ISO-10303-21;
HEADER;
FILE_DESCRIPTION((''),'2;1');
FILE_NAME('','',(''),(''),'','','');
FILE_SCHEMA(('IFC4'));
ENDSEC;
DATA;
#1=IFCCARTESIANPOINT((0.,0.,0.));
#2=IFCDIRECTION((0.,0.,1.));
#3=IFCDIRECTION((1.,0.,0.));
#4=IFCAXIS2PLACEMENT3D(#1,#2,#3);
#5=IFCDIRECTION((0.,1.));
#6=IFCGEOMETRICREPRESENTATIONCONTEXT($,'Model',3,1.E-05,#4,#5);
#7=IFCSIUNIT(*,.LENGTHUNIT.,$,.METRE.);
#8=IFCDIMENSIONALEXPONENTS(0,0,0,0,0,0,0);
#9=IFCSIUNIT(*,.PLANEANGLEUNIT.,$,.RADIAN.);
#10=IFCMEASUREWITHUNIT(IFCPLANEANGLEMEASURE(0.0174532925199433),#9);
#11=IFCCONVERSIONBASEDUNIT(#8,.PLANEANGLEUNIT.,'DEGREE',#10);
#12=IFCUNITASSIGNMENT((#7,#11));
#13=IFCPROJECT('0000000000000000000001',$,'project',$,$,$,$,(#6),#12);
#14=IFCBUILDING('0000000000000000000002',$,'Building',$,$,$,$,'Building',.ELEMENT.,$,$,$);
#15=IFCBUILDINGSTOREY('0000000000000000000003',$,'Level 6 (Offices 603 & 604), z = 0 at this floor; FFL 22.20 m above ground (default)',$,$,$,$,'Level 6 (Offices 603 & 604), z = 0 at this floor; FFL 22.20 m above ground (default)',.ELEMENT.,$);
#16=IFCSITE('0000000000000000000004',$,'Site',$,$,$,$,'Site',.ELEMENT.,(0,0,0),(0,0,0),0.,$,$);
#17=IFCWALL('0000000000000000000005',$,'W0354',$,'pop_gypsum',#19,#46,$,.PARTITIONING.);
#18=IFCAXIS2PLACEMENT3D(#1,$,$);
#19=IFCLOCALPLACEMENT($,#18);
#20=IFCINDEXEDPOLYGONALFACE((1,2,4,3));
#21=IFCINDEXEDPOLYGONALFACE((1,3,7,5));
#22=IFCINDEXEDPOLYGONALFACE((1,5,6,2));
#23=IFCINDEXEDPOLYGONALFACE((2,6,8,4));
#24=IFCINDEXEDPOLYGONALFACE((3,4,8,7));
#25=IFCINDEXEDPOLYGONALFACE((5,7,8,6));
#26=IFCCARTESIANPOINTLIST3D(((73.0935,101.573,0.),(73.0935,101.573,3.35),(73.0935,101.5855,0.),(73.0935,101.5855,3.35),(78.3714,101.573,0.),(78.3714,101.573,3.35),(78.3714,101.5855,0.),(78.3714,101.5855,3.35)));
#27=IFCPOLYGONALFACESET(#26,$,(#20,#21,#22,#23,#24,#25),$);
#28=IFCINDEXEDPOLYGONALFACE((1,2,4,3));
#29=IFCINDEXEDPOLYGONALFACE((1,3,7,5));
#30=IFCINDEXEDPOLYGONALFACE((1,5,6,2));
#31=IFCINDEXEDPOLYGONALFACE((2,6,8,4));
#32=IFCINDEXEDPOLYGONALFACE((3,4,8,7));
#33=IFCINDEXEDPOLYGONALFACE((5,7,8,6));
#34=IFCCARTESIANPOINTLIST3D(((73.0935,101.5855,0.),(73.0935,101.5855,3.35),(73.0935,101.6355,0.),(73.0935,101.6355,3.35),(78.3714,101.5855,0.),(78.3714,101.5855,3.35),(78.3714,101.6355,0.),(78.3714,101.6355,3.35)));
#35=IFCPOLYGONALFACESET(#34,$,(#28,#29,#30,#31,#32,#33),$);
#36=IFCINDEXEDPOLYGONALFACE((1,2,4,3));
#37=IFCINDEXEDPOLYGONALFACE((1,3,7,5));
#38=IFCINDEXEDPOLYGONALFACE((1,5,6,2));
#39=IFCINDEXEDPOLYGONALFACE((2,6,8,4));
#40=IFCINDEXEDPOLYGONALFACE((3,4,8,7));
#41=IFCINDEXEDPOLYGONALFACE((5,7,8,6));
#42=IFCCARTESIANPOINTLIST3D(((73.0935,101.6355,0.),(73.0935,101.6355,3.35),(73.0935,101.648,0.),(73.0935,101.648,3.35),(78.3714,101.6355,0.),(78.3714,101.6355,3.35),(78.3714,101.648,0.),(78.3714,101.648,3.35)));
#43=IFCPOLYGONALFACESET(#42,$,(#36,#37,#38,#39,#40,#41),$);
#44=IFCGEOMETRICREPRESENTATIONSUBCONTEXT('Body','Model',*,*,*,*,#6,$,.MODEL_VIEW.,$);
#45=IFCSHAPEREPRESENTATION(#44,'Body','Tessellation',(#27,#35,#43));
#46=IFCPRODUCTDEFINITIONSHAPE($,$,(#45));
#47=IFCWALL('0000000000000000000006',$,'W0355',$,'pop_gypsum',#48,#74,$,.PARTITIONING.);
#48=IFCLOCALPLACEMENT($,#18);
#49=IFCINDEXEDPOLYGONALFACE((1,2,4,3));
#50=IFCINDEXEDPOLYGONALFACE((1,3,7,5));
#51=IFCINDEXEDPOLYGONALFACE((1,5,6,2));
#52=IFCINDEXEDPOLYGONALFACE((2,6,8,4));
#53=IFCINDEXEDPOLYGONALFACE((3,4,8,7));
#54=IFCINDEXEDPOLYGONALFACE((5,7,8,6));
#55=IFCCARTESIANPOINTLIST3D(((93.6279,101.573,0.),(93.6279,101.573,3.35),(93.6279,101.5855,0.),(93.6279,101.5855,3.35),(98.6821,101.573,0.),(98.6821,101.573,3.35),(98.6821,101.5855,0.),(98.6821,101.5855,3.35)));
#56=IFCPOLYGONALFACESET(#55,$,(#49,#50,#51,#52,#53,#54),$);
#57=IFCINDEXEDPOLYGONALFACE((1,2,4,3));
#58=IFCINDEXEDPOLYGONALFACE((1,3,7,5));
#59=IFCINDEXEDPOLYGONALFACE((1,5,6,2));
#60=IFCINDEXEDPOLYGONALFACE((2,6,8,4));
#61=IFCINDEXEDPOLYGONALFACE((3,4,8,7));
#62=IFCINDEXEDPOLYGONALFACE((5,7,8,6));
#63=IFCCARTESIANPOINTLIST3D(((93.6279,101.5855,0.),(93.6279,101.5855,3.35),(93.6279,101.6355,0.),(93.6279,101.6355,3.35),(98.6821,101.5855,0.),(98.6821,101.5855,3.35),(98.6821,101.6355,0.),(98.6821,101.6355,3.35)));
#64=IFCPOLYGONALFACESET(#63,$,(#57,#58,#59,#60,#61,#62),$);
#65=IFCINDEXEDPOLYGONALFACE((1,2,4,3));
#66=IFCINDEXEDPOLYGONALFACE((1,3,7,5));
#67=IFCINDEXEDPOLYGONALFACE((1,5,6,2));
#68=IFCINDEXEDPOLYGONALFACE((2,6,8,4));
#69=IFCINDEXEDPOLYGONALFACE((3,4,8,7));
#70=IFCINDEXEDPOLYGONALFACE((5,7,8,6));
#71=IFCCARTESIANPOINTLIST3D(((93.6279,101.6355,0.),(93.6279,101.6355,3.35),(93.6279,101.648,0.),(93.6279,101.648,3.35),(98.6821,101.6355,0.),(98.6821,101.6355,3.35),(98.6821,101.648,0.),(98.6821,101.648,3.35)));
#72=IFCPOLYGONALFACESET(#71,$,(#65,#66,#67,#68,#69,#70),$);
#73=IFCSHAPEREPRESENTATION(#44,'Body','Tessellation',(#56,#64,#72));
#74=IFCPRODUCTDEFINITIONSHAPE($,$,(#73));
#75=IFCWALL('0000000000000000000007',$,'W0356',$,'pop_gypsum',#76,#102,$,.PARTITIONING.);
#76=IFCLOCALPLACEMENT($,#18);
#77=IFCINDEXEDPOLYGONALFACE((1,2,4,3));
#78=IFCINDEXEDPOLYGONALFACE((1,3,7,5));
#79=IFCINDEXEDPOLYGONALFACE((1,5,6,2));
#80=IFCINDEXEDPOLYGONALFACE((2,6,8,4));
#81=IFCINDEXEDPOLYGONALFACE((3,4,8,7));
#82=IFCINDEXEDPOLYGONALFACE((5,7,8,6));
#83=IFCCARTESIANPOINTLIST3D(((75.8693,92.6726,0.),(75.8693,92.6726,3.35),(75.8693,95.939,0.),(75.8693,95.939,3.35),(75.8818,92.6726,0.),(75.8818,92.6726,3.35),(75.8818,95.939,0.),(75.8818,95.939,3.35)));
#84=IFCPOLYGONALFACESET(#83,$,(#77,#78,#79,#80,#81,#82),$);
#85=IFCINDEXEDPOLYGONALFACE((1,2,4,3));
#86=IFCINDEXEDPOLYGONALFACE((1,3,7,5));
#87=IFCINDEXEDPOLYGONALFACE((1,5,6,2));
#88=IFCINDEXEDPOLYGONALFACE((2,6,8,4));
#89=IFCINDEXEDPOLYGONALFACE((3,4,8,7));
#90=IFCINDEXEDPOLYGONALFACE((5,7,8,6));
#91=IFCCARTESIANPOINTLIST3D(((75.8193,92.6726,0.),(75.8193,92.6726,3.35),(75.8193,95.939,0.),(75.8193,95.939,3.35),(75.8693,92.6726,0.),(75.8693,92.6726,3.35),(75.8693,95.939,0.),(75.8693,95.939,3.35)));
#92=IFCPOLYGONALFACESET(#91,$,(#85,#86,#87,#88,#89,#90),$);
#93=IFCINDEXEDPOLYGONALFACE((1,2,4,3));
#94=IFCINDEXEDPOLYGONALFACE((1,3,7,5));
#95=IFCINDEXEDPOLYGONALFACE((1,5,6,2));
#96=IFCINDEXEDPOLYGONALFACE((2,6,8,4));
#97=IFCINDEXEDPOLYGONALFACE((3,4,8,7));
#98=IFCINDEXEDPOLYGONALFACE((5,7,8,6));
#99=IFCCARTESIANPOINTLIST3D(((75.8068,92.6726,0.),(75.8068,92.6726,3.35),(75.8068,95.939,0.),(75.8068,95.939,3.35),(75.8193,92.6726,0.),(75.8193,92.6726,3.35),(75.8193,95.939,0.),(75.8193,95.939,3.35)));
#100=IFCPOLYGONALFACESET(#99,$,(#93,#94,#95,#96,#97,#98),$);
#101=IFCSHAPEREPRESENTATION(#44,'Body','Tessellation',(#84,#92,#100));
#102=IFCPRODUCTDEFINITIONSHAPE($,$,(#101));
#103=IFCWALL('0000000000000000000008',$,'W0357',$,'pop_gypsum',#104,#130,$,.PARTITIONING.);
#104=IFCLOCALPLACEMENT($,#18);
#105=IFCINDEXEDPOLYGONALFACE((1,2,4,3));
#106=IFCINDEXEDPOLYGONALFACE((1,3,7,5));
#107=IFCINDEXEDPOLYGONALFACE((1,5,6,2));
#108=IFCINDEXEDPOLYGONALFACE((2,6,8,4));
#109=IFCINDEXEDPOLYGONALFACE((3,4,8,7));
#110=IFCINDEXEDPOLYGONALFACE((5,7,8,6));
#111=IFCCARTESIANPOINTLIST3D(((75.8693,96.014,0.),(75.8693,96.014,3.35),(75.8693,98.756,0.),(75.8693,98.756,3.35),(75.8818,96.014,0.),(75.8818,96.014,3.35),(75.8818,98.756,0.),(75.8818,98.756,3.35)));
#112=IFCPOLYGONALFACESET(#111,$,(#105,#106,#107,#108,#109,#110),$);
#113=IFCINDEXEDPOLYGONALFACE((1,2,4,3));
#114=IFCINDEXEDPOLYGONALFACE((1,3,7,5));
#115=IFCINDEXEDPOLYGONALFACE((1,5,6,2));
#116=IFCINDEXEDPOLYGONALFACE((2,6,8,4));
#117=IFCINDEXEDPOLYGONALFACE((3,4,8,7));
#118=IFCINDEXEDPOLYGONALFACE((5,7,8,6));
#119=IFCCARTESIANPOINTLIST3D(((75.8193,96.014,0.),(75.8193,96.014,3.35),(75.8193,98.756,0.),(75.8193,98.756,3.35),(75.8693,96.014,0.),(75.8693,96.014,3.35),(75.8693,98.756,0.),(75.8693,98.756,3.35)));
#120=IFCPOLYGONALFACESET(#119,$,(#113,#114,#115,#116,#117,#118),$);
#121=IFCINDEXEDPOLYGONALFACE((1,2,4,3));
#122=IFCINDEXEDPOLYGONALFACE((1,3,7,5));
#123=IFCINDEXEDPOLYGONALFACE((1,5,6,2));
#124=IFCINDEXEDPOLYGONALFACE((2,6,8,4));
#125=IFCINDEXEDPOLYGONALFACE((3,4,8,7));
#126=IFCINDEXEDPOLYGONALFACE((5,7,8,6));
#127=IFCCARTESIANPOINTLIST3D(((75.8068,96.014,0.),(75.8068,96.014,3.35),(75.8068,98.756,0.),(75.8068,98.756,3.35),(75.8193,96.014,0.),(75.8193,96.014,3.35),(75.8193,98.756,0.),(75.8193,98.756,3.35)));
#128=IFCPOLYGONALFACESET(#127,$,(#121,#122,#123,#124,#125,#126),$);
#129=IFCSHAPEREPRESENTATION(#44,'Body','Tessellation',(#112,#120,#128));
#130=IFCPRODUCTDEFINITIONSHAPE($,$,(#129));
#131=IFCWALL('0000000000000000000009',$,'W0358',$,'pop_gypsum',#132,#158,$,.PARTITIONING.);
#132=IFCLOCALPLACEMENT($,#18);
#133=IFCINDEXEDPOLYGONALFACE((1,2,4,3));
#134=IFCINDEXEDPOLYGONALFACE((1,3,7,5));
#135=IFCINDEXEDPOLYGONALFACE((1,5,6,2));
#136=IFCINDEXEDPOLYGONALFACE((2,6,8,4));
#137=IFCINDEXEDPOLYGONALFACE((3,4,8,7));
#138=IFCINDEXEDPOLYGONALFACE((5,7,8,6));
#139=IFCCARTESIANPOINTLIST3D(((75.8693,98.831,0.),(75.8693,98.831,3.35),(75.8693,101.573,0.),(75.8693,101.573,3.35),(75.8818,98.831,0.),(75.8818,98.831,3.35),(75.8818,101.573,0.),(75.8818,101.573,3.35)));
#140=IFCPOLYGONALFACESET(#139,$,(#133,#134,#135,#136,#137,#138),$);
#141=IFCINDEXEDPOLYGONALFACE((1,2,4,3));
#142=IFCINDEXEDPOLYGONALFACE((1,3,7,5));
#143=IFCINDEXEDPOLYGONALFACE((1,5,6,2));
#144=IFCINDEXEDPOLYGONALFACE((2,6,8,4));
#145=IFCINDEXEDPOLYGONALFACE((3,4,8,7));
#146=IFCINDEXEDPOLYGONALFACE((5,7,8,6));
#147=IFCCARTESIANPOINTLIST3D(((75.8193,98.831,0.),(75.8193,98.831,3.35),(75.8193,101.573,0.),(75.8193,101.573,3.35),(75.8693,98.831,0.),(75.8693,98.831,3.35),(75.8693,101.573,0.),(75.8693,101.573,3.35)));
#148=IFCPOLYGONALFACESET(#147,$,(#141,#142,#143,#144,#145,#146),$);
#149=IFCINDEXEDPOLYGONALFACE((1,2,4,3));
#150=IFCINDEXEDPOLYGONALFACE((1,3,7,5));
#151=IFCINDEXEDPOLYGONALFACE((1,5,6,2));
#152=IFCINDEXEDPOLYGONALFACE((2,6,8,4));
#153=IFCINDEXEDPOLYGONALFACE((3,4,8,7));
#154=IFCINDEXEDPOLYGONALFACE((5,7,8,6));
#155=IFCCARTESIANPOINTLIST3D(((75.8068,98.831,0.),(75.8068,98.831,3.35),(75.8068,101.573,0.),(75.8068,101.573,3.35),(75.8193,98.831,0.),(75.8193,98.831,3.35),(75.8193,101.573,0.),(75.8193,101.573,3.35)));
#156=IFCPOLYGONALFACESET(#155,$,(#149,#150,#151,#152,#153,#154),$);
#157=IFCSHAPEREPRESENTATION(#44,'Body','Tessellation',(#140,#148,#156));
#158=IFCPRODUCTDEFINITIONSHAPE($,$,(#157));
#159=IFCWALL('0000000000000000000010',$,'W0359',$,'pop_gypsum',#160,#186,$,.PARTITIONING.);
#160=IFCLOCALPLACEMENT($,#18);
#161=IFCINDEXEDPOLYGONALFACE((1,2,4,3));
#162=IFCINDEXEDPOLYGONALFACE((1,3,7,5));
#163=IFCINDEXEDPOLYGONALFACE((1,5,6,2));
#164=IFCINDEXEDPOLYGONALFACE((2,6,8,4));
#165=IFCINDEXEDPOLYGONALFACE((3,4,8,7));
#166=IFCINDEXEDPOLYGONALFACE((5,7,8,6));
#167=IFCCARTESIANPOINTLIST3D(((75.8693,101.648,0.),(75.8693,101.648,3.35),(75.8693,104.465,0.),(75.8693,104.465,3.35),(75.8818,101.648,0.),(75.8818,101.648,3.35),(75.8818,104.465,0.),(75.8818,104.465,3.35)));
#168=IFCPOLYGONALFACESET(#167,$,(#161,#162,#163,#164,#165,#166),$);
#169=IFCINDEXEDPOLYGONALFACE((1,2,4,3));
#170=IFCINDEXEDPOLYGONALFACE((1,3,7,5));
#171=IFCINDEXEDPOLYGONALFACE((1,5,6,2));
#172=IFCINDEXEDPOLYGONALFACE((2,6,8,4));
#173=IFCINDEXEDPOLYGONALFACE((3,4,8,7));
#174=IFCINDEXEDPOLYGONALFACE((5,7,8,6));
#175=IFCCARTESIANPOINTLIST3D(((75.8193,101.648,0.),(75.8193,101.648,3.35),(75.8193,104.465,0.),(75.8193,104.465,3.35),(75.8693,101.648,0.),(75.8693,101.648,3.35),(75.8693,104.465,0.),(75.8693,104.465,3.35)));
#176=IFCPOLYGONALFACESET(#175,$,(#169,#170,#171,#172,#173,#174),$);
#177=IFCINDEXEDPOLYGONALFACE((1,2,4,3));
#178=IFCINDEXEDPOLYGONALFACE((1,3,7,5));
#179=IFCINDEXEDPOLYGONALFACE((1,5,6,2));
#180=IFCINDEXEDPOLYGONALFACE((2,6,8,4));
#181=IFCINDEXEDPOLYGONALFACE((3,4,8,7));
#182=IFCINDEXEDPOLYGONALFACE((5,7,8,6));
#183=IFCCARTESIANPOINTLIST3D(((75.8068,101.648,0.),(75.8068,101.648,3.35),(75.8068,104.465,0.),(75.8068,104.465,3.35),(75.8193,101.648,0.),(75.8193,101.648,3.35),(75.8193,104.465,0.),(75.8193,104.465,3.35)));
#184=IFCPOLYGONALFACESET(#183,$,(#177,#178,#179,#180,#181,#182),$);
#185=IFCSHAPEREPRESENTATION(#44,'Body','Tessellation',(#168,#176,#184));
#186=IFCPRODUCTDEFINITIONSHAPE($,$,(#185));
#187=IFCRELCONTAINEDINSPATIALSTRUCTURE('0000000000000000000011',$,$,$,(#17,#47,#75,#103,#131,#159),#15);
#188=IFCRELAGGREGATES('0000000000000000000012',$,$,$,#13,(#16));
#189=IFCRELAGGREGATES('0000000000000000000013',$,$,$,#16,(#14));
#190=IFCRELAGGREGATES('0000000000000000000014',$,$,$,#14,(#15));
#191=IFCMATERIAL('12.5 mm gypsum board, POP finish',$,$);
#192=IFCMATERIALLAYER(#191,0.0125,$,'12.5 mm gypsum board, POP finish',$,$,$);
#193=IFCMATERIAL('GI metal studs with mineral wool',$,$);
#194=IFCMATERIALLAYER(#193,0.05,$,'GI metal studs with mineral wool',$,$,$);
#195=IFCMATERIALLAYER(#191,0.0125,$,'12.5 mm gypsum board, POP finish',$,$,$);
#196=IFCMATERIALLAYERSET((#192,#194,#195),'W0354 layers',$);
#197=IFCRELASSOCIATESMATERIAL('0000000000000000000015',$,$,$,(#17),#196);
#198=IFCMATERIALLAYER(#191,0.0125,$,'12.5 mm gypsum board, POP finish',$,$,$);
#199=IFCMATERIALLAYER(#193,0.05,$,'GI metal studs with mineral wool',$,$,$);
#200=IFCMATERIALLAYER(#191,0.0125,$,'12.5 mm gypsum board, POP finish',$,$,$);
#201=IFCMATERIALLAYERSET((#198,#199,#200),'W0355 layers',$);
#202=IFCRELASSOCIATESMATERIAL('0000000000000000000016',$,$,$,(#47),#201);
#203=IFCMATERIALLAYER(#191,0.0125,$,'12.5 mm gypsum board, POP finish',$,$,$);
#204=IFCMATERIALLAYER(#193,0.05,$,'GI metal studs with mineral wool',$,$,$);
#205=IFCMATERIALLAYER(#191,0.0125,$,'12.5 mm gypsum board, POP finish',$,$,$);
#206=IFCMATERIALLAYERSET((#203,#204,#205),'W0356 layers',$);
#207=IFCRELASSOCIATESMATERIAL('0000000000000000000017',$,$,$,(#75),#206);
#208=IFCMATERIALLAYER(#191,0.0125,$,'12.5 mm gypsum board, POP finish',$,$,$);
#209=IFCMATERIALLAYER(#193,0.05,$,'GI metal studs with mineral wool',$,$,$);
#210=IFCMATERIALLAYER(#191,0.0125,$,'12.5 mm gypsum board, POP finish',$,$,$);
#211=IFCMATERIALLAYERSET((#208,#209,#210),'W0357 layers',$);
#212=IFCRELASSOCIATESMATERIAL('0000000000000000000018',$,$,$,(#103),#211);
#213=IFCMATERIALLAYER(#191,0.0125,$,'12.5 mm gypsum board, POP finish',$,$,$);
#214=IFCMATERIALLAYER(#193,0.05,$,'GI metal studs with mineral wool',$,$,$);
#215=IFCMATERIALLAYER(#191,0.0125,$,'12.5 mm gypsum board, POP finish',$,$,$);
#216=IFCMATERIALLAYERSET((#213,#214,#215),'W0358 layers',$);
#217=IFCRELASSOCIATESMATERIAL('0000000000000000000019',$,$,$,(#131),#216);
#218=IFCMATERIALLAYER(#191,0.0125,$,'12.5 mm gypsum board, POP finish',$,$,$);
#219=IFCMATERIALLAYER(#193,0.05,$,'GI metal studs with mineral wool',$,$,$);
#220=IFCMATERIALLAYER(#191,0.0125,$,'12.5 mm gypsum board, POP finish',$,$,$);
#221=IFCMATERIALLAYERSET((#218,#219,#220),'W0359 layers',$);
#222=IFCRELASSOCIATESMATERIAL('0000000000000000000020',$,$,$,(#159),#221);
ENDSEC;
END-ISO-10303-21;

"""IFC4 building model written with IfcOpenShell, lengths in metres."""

from ifc_helpers import new_model, entity, si_unit, converted_unit, direction, frame, frame_2d, origin_with_axes, place, context, subcontext, project, spatial, rectangle, extrude, material, layer, layer_set, layer_usage, element, save


model = new_model("IFC4")

# Units and contexts
model_context = context("Model", 3, precision=1e-05, world=origin_with_axes(), true_north=direction((0.0, 1.0)))
body_context = subcontext(model_context, "Body", "Model", "MODEL_VIEW")
ifc_project = project(units=[si_unit("LENGTHUNIT", "METRE"), converted_unit("PLANEANGLEUNIT", "DEGREE", entity("IfcPlaneAngleMeasure", 0.0174532925199433), si_unit("PLANEANGLEUNIT", "RADIAN"), dimensions=[0, 0, 0, 0, 0, 0, 0])], contexts=[model_context])

# Site, building, storey
site = spatial("IfcSite", under=ifc_project, Name="Site", LongName="Site", CompositionType="ELEMENT", RefLatitude=(0, 0, 0), RefLongitude=(0, 0, 0), RefElevation=0.0)
building = spatial("IfcBuilding", under=site, Name="Building", LongName="Building", CompositionType="ELEMENT")
storey = spatial("IfcBuildingStorey", under=building, Name="Level 6 (Offices 603 & 604), z = 0 at this floor; FFL 22.20 m above ground (default)", LongName="Level 6 (Offices 603 & 604), z = 0 at this floor; FFL 22.20 m above ground (default)", CompositionType="ELEMENT")

# Shared definitions
placement = place(None, origin_with_axes())

# Walls
ifc_material_1 = material(Name="12.5 mm gypsum board, POP finish")
ifc_material_2 = material(Name="GI metal studs with mineral wool")
ifc_layer_1 = layer(ifc_material_1, 0.0125, Name="12.5 mm gypsum board, POP finish")
ifc_layer_2 = layer(ifc_material_2, 0.05, Name="GI metal studs with mineral wool")
ifc_layer_3 = layer(ifc_material_1, 0.0125, Name="12.5 mm gypsum board, POP finish")
ifc_layer_set_1 = layer_set([ifc_layer_1, ifc_layer_2, ifc_layer_3], Name="W0354 layers")
ifc_layer_usage_1 = layer_usage(ifc_layer_set_1, "AXIS2", "POSITIVE", -0.0375)
element("IfcWall", 1, at=placement, inside=storey, material=ifc_layer_usage_1, Name="W0354", ObjectType="pop_gypsum", PredefinedType="PARTITIONING", context=body_context, shape_type="SweptSolid", body=[
    extrude(rectangle(XDim=5.2779, YDim=0.0125, at=frame_2d((0.0, 0.0), x_axis=(1.0, 0.0))), frame((75.7325, 101.5793, 0.0), z_axis=(0.0, 0.0, 1.0), x_axis=(1.0, 0.0, 0.0)), (0.0, 0.0, 1.0), 3.35),
    extrude(rectangle(XDim=5.2779, YDim=0.05, at=frame_2d((0.0, 0.0312), x_axis=(1.0, 0.0))), frame((75.7325, 101.5793, 0.0), z_axis=(0.0, 0.0, 1.0), x_axis=(1.0, 0.0, 0.0)), (0.0, 0.0, 1.0), 3.35),
    extrude(rectangle(XDim=5.2779, YDim=0.0125, at=frame_2d((0.0, 0.0625), x_axis=(1.0, 0.0))), frame((75.7325, 101.5793, 0.0), z_axis=(0.0, 0.0, 1.0), x_axis=(1.0, 0.0, 0.0)), (0.0, 0.0, 1.0), 3.35),
])
ifc_layer_4 = layer(ifc_material_1, 0.0125, Name="12.5 mm gypsum board, POP finish")
ifc_layer_5 = layer(ifc_material_2, 0.05, Name="GI metal studs with mineral wool")
ifc_layer_6 = layer(ifc_material_1, 0.0125, Name="12.5 mm gypsum board, POP finish")
ifc_layer_set_2 = layer_set([ifc_layer_4, ifc_layer_5, ifc_layer_6], Name="W0355 layers")
ifc_layer_usage_2 = layer_usage(ifc_layer_set_2, "AXIS2", "POSITIVE", -0.0375)
element("IfcWall", 2, at=placement, inside=storey, material=ifc_layer_usage_2, Name="W0355", ObjectType="pop_gypsum", PredefinedType="PARTITIONING", context=body_context, shape_type="SweptSolid", body=[
    extrude(rectangle(XDim=5.0542, YDim=0.0125, at=frame_2d((0.0, 0.0), x_axis=(1.0, 0.0))), frame((96.155, 101.5793, 0.0), z_axis=(0.0, 0.0, 1.0), x_axis=(1.0, 0.0, 0.0)), (0.0, 0.0, 1.0), 3.35),
    extrude(rectangle(XDim=5.0542, YDim=0.05, at=frame_2d((0.0, 0.0312), x_axis=(1.0, 0.0))), frame((96.155, 101.5793, 0.0), z_axis=(0.0, 0.0, 1.0), x_axis=(1.0, 0.0, 0.0)), (0.0, 0.0, 1.0), 3.35),
    extrude(rectangle(XDim=5.0542, YDim=0.0125, at=frame_2d((0.0, 0.0625), x_axis=(1.0, 0.0))), frame((96.155, 101.5793, 0.0), z_axis=(0.0, 0.0, 1.0), x_axis=(1.0, 0.0, 0.0)), (0.0, 0.0, 1.0), 3.35),
])
ifc_layer_7 = layer(ifc_material_1, 0.0125, Name="12.5 mm gypsum board, POP finish")
ifc_layer_8 = layer(ifc_material_2, 0.05, Name="GI metal studs with mineral wool")
ifc_layer_9 = layer(ifc_material_1, 0.0125, Name="12.5 mm gypsum board, POP finish")
ifc_layer_set_3 = layer_set([ifc_layer_7, ifc_layer_8, ifc_layer_9], Name="W0356 layers")
ifc_layer_usage_3 = layer_usage(ifc_layer_set_3, "AXIS2", "POSITIVE", -0.0375)
element("IfcWall", 3, at=placement, inside=storey, material=ifc_layer_usage_3, Name="W0356", ObjectType="pop_gypsum", PredefinedType="PARTITIONING", context=body_context, shape_type="SweptSolid", body=[
    extrude(rectangle(XDim=3.2664, YDim=0.0125, at=frame_2d((0.0, 0.0), x_axis=(0.0, 1.0))), frame((75.8756, 94.3058, 0.0), z_axis=(0.0, 0.0, 1.0), x_axis=(1.0, 0.0, 0.0)), (0.0, 0.0, 1.0), 3.35),
    extrude(rectangle(XDim=3.2664, YDim=0.05, at=frame_2d((-0.0312, 0.0), x_axis=(0.0, 1.0))), frame((75.8756, 94.3058, 0.0), z_axis=(0.0, 0.0, 1.0), x_axis=(1.0, 0.0, 0.0)), (0.0, 0.0, 1.0), 3.35),
    extrude(rectangle(XDim=3.2664, YDim=0.0125, at=frame_2d((-0.0625, 0.0), x_axis=(0.0, 1.0))), frame((75.8756, 94.3058, 0.0), z_axis=(0.0, 0.0, 1.0), x_axis=(1.0, 0.0, 0.0)), (0.0, 0.0, 1.0), 3.35),
])
ifc_layer_10 = layer(ifc_material_1, 0.0125, Name="12.5 mm gypsum board, POP finish")
ifc_layer_11 = layer(ifc_material_2, 0.05, Name="GI metal studs with mineral wool")
ifc_layer_12 = layer(ifc_material_1, 0.0125, Name="12.5 mm gypsum board, POP finish")
ifc_layer_set_4 = layer_set([ifc_layer_10, ifc_layer_11, ifc_layer_12], Name="W0357 layers")
ifc_layer_usage_4 = layer_usage(ifc_layer_set_4, "AXIS2", "POSITIVE", -0.0375)
element("IfcWall", 4, at=placement, inside=storey, material=ifc_layer_usage_4, Name="W0357", ObjectType="pop_gypsum", PredefinedType="PARTITIONING", context=body_context, shape_type="SweptSolid", body=[
    extrude(rectangle(XDim=2.742, YDim=0.0125, at=frame_2d((0.0, 0.0), x_axis=(0.0, 1.0))), frame((75.8756, 97.385, 0.0), z_axis=(0.0, 0.0, 1.0), x_axis=(1.0, 0.0, 0.0)), (0.0, 0.0, 1.0), 3.35),
    extrude(rectangle(XDim=2.742, YDim=0.05, at=frame_2d((-0.0312, 0.0), x_axis=(0.0, 1.0))), frame((75.8756, 97.385, 0.0), z_axis=(0.0, 0.0, 1.0), x_axis=(1.0, 0.0, 0.0)), (0.0, 0.0, 1.0), 3.35),
    extrude(rectangle(XDim=2.742, YDim=0.0125, at=frame_2d((-0.0625, 0.0), x_axis=(0.0, 1.0))), frame((75.8756, 97.385, 0.0), z_axis=(0.0, 0.0, 1.0), x_axis=(1.0, 0.0, 0.0)), (0.0, 0.0, 1.0), 3.35),
])
ifc_layer_13 = layer(ifc_material_1, 0.0125, Name="12.5 mm gypsum board, POP finish")
ifc_layer_14 = layer(ifc_material_2, 0.05, Name="GI metal studs with mineral wool")
ifc_layer_15 = layer(ifc_material_1, 0.0125, Name="12.5 mm gypsum board, POP finish")
ifc_layer_set_5 = layer_set([ifc_layer_13, ifc_layer_14, ifc_layer_15], Name="W0358 layers")
ifc_layer_usage_5 = layer_usage(ifc_layer_set_5, "AXIS2", "POSITIVE", -0.0375)
element("IfcWall", 5, at=placement, inside=storey, material=ifc_layer_usage_5, Name="W0358", ObjectType="pop_gypsum", PredefinedType="PARTITIONING", context=body_context, shape_type="SweptSolid", body=[
    extrude(rectangle(XDim=2.742, YDim=0.0125, at=frame_2d((0.0, 0.0), x_axis=(0.0, 1.0))), frame((75.8756, 100.202, 0.0), z_axis=(0.0, 0.0, 1.0), x_axis=(1.0, 0.0, 0.0)), (0.0, 0.0, 1.0), 3.35),
    extrude(rectangle(XDim=2.742, YDim=0.05, at=frame_2d((-0.0312, 0.0), x_axis=(0.0, 1.0))), frame((75.8756, 100.202, 0.0), z_axis=(0.0, 0.0, 1.0), x_axis=(1.0, 0.0, 0.0)), (0.0, 0.0, 1.0), 3.35),
    extrude(rectangle(XDim=2.742, YDim=0.0125, at=frame_2d((-0.0625, 0.0), x_axis=(0.0, 1.0))), frame((75.8756, 100.202, 0.0), z_axis=(0.0, 0.0, 1.0), x_axis=(1.0, 0.0, 0.0)), (0.0, 0.0, 1.0), 3.35),
])
ifc_layer_16 = layer(ifc_material_1, 0.0125, Name="12.5 mm gypsum board, POP finish")
ifc_layer_17 = layer(ifc_material_2, 0.05, Name="GI metal studs with mineral wool")
ifc_layer_18 = layer(ifc_material_1, 0.0125, Name="12.5 mm gypsum board, POP finish")
ifc_layer_set_6 = layer_set([ifc_layer_16, ifc_layer_17, ifc_layer_18], Name="W0359 layers")
ifc_layer_usage_6 = layer_usage(ifc_layer_set_6, "AXIS2", "POSITIVE", -0.0375)
element("IfcWall", 6, at=placement, inside=storey, material=ifc_layer_usage_6, Name="W0359", ObjectType="pop_gypsum", PredefinedType="PARTITIONING", context=body_context, shape_type="SweptSolid", body=[
    extrude(rectangle(XDim=2.817, YDim=0.0125, at=frame_2d((0.0, 0.0), x_axis=(0.0, 1.0))), frame((75.8756, 103.0565, 0.0), z_axis=(0.0, 0.0, 1.0), x_axis=(1.0, 0.0, 0.0)), (0.0, 0.0, 1.0), 3.35),
    extrude(rectangle(XDim=2.817, YDim=0.05, at=frame_2d((-0.0312, 0.0), x_axis=(0.0, 1.0))), frame((75.8756, 103.0565, 0.0), z_axis=(0.0, 0.0, 1.0), x_axis=(1.0, 0.0, 0.0)), (0.0, 0.0, 1.0), 3.35),
    extrude(rectangle(XDim=2.817, YDim=0.0125, at=frame_2d((-0.0625, 0.0), x_axis=(0.0, 1.0))), frame((75.8756, 103.0565, 0.0), z_axis=(0.0, 0.0, 1.0), x_axis=(1.0, 0.0, 0.0)), (0.0, 0.0, 1.0), 3.35),
])

save(model, "model.ifc")
